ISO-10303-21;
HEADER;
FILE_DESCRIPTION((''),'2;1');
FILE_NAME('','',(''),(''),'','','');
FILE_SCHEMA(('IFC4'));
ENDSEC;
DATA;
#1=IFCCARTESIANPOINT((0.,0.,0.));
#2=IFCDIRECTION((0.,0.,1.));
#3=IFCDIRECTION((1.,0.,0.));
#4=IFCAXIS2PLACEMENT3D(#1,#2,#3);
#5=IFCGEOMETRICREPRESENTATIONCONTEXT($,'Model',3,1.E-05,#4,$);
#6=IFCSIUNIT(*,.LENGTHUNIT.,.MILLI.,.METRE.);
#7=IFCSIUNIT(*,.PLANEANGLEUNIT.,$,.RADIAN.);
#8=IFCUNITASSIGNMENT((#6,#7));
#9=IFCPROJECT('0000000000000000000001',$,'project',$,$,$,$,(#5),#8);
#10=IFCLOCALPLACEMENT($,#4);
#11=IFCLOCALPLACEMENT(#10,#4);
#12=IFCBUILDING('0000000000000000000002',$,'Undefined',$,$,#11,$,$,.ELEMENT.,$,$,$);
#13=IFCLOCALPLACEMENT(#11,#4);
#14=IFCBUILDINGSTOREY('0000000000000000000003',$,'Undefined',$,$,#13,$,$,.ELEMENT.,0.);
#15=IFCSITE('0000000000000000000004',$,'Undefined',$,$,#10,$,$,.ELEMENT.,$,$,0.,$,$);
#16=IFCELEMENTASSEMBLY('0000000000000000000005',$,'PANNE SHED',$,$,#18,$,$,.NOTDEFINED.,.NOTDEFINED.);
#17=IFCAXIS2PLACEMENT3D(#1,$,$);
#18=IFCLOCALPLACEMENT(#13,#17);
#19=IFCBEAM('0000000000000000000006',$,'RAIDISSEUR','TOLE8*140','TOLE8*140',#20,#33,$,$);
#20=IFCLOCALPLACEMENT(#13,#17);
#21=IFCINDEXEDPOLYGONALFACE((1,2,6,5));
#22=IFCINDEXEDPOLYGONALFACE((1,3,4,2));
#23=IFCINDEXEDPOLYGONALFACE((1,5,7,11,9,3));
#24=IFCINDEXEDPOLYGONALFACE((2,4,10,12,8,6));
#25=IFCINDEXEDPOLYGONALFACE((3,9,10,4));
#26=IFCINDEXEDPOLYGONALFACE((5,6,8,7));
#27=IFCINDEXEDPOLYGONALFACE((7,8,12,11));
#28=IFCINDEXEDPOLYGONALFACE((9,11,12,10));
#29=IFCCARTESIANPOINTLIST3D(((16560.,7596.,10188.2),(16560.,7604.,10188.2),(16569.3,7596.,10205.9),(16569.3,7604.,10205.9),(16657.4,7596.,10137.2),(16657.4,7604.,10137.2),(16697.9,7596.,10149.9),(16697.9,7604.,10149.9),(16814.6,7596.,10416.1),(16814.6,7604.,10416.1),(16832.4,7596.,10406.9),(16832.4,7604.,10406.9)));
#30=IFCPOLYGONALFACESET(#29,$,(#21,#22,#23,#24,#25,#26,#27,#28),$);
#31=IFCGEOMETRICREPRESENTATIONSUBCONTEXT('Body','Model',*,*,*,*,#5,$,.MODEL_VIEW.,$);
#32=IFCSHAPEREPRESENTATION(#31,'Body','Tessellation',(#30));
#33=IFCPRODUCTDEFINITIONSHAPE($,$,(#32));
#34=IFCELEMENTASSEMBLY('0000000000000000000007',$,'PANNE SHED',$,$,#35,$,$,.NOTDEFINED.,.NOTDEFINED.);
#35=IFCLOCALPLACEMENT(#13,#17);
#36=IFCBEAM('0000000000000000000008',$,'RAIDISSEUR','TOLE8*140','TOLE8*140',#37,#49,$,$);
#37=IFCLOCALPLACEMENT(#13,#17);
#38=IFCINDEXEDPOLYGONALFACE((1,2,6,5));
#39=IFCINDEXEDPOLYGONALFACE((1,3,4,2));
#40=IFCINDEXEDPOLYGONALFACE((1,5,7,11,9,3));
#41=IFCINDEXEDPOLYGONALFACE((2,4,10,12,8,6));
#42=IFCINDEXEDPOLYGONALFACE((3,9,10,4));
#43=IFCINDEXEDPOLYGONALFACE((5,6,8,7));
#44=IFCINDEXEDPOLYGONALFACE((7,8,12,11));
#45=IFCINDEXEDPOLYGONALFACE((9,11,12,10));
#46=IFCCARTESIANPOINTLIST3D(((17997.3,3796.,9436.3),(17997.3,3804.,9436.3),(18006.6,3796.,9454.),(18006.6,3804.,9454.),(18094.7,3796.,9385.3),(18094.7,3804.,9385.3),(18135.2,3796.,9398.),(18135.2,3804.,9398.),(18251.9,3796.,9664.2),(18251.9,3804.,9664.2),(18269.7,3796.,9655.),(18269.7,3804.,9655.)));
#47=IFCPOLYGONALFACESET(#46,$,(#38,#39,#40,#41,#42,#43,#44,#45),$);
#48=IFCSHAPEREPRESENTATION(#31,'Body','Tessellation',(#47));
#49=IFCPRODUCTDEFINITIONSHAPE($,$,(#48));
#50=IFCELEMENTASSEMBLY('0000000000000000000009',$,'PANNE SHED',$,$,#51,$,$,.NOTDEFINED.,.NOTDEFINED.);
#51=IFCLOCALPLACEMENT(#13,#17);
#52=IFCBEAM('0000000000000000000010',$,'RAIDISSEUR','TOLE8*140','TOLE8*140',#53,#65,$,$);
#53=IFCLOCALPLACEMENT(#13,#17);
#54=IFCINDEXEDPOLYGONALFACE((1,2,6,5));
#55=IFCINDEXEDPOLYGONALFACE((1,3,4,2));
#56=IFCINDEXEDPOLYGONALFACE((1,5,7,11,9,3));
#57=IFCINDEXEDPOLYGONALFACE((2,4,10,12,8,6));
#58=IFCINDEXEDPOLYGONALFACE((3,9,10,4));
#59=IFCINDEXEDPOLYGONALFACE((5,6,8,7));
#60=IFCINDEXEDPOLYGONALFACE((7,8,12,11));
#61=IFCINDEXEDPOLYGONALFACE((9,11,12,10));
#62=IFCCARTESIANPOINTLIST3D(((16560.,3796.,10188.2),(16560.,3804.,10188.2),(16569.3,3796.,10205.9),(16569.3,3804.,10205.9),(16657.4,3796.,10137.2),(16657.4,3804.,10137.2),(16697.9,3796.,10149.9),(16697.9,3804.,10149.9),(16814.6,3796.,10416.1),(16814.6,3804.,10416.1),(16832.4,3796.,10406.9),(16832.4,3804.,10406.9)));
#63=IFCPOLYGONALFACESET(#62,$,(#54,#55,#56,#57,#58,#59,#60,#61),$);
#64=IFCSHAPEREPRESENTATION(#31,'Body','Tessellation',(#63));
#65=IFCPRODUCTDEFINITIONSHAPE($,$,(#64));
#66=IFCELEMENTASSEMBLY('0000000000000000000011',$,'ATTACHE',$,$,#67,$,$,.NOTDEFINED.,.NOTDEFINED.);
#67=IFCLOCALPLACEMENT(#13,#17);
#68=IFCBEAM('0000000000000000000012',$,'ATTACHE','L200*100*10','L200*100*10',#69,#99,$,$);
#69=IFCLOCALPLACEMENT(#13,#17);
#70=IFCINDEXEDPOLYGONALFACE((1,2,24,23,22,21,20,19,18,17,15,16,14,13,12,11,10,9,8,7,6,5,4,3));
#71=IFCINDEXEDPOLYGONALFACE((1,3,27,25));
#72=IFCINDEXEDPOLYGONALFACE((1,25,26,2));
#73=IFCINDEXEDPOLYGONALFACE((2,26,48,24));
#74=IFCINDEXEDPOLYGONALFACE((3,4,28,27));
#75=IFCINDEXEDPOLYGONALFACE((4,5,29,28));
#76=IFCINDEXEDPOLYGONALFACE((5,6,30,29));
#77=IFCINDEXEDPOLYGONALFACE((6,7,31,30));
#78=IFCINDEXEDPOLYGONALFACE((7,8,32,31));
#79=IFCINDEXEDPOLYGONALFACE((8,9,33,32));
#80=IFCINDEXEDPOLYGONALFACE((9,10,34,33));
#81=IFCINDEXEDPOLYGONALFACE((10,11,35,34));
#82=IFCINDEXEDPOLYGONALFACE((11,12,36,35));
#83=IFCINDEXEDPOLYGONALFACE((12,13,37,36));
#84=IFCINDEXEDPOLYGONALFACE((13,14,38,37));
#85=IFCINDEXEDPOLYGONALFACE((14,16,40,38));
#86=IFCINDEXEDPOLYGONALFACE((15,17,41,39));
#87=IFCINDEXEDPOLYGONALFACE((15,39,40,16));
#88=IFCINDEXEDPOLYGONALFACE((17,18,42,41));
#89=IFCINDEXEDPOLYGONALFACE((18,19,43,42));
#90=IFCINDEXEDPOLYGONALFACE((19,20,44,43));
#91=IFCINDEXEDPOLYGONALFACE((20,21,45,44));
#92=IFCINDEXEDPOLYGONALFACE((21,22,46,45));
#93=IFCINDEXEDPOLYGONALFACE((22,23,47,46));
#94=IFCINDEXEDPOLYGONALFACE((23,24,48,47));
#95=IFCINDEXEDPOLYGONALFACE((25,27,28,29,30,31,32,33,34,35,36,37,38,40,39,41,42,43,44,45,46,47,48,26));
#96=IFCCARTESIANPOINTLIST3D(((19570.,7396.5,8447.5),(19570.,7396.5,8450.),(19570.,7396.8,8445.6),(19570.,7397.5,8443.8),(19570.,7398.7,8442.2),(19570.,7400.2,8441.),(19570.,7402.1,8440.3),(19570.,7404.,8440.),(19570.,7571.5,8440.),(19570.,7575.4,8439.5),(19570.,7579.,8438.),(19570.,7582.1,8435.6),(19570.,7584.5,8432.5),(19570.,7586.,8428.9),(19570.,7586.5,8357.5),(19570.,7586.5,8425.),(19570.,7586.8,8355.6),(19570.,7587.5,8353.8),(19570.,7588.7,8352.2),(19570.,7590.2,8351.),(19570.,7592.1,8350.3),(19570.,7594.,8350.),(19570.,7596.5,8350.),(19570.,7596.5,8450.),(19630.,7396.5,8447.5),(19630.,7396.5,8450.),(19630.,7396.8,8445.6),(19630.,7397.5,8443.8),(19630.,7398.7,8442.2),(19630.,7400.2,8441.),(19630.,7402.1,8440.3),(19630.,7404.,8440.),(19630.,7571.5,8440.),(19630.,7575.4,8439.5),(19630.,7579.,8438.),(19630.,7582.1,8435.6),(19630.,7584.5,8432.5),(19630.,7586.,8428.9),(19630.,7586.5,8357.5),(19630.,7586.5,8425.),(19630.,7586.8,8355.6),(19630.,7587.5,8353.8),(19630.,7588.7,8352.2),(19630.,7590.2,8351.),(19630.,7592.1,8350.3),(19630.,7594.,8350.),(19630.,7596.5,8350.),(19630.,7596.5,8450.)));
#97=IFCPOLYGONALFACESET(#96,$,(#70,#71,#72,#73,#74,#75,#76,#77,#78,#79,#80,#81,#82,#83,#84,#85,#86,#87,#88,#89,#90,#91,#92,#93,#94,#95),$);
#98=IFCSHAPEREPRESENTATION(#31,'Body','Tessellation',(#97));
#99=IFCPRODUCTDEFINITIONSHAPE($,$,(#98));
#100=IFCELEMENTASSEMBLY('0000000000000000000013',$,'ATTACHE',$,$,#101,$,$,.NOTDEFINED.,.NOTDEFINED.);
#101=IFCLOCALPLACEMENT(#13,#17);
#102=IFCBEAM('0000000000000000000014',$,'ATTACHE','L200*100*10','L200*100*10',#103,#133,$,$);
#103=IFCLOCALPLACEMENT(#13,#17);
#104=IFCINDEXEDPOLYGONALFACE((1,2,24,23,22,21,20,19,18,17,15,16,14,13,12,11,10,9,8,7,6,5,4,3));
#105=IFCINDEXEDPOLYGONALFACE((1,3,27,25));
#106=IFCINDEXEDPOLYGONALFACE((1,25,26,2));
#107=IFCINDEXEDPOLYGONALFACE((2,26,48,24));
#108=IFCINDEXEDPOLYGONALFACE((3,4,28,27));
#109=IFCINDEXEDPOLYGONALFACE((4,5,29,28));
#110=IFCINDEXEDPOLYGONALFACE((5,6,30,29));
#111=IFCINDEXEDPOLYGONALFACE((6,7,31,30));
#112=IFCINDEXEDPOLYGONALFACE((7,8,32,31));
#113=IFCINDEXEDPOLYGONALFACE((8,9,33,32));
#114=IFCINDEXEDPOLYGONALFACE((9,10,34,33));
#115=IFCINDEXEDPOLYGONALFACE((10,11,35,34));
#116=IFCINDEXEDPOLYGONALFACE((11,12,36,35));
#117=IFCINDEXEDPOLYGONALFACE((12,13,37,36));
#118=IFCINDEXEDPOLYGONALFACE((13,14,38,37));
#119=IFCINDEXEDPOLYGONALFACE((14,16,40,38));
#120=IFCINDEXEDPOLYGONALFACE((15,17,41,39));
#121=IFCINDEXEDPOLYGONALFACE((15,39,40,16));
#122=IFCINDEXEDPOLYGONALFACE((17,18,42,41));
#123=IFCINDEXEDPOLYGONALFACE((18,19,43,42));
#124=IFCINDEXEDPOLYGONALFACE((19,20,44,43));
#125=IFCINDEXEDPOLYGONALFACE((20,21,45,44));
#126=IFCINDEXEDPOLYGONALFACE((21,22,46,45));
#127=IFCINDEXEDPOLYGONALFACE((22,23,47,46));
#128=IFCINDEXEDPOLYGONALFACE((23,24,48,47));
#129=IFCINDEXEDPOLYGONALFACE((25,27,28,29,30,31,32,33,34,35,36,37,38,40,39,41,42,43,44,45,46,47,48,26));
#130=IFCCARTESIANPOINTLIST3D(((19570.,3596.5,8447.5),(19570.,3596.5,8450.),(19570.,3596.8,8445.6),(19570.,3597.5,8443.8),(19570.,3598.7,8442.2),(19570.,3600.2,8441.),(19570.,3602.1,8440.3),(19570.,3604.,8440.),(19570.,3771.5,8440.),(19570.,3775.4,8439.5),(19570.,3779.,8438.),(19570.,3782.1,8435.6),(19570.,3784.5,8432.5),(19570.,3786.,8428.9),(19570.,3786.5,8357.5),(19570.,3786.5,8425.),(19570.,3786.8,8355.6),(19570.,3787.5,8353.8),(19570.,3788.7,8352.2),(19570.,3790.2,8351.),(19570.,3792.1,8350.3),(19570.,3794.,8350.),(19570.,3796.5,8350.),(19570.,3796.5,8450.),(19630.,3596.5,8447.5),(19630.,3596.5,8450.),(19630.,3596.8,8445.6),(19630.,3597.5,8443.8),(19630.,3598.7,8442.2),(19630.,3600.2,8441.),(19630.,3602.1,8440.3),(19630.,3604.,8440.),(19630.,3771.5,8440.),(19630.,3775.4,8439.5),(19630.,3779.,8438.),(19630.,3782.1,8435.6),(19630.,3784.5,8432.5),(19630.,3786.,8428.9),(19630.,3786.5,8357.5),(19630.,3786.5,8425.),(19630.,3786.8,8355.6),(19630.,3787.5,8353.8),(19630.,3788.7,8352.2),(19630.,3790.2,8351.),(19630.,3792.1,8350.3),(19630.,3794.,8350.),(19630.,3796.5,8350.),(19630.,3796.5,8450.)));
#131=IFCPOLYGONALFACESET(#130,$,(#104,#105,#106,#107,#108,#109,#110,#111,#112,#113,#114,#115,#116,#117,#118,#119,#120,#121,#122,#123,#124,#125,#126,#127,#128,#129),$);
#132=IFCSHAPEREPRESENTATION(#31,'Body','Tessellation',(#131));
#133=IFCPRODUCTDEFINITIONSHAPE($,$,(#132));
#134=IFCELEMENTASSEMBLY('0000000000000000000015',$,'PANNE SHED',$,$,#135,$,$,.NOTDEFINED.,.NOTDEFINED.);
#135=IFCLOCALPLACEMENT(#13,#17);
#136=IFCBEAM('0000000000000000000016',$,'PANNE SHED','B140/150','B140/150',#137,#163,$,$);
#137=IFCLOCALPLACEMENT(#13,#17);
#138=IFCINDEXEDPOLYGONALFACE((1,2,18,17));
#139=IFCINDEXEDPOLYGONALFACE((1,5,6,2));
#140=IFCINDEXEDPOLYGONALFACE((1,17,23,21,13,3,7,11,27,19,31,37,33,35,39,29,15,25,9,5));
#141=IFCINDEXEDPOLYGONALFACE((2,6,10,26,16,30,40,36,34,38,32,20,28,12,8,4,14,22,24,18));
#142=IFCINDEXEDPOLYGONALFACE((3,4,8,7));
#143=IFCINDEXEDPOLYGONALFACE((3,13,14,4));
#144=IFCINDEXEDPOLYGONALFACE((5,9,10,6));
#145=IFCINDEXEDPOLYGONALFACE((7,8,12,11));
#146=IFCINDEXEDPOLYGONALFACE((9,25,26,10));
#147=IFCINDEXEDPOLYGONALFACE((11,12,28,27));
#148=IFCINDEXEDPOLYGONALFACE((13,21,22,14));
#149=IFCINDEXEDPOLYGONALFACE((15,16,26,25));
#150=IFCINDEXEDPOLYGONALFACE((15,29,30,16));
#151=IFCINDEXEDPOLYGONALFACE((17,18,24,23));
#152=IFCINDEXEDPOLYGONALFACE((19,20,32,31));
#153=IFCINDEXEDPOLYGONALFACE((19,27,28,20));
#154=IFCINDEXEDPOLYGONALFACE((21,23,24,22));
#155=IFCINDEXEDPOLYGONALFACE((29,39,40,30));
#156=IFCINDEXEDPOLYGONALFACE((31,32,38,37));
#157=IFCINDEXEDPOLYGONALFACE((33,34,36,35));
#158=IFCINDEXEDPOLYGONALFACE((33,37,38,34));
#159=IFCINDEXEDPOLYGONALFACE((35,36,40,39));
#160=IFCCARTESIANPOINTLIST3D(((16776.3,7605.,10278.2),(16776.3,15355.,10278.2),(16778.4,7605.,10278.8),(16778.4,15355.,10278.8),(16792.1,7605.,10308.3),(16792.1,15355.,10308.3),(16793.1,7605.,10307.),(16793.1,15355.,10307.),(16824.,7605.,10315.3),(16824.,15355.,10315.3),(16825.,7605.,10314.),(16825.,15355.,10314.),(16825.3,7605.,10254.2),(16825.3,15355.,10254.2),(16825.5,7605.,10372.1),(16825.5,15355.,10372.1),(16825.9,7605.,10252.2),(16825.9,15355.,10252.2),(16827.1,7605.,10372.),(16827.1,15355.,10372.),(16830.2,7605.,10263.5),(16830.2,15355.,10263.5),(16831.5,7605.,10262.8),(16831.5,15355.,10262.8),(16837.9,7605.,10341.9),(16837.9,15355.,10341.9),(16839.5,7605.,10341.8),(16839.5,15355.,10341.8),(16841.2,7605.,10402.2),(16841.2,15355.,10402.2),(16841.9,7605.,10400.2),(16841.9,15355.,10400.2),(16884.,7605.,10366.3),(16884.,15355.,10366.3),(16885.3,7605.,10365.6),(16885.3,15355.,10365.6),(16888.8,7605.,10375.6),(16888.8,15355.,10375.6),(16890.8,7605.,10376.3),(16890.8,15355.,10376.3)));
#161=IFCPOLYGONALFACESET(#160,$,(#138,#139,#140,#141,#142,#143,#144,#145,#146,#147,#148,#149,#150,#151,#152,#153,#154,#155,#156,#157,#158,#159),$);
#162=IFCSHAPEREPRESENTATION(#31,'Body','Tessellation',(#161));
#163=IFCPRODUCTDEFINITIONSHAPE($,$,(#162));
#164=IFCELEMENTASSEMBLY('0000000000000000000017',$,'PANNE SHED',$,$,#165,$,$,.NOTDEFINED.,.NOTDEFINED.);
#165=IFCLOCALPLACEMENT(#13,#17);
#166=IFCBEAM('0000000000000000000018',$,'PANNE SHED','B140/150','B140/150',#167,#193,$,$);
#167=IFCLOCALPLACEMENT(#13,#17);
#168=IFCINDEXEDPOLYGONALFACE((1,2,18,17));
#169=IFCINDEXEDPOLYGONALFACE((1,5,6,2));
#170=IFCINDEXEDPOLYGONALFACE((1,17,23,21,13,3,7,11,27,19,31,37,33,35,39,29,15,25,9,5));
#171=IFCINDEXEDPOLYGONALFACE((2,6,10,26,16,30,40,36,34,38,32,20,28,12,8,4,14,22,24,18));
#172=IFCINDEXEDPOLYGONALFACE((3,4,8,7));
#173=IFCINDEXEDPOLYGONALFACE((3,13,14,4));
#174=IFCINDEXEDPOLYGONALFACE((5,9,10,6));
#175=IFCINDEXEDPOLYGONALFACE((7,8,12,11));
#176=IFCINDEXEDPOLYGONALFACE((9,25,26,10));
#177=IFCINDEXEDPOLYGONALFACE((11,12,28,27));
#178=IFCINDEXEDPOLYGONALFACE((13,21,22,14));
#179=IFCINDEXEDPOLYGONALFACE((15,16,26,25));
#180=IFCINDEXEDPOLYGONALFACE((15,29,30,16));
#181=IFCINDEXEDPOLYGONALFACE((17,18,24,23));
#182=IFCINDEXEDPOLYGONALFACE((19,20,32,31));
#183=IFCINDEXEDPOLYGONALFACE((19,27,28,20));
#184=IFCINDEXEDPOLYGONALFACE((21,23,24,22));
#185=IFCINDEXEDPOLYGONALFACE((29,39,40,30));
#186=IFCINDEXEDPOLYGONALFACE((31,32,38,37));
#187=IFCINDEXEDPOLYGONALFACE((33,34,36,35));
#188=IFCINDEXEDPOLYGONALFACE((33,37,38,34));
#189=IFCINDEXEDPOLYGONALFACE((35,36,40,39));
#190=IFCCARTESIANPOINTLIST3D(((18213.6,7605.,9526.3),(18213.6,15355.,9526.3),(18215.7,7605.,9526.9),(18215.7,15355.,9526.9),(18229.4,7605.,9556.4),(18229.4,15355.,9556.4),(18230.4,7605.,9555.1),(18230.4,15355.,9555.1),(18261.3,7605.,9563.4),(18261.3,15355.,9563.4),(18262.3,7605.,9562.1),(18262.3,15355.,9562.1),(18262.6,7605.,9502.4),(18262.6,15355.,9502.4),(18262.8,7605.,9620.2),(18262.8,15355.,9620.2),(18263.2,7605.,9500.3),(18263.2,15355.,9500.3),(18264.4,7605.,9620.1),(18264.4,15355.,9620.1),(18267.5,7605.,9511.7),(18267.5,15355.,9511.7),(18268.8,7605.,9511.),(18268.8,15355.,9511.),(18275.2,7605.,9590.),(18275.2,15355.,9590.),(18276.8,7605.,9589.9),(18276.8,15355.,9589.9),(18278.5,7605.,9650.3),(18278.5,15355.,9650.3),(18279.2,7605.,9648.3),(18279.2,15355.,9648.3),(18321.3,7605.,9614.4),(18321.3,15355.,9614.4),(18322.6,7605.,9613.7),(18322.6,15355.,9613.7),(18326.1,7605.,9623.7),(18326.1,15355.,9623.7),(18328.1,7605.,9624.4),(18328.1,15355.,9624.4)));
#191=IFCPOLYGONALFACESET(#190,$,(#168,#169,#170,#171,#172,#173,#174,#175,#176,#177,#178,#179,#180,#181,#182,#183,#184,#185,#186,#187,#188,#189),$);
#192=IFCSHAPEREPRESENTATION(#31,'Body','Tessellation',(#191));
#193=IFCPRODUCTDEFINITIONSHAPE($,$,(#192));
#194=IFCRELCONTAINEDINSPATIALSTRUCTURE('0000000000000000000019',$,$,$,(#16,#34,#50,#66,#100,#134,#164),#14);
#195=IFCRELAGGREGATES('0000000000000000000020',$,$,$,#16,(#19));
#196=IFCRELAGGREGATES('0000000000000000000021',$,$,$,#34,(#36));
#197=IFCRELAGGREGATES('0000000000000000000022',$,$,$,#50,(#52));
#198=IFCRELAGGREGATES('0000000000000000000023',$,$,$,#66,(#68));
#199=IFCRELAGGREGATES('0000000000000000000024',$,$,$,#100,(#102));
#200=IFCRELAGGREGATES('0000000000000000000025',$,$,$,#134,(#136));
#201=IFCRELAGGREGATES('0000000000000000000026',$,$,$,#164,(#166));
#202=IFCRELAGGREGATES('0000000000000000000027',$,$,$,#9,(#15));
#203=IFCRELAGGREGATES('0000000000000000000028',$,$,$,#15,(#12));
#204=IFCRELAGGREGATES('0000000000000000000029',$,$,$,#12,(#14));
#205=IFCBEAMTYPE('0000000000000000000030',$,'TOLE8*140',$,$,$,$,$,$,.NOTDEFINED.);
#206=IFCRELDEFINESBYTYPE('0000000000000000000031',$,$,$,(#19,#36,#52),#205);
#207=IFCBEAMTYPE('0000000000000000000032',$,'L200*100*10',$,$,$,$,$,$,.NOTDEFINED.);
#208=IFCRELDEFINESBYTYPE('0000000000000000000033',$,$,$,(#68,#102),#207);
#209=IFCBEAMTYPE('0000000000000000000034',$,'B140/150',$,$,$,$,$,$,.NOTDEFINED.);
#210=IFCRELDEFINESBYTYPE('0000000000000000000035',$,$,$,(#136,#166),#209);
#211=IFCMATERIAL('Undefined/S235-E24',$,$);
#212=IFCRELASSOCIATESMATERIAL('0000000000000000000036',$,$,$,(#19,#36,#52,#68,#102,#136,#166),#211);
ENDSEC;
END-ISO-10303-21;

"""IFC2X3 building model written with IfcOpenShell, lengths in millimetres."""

from ifc_helpers import new_model, si_unit, frame, origin_with_axes, origin_2d_with_axis, place, context, subcontext, project, spatial, polyline, l_section, outline, extrude, material, type_object, element, aggregate, save


model = new_model("IFC2X3")

# Units and contexts
model_context = context("Model", 3, precision=1e-05, world=origin_with_axes())
body_context = subcontext(model_context, "Body", "Model", "MODEL_VIEW")
ifc_project = project(units=[si_unit("LENGTHUNIT", "METRE", prefix="MILLI"), si_unit("PLANEANGLEUNIT", "RADIAN")], contexts=[model_context])

# Site, building, storey
site_placement = place(None, origin_with_axes())
site = spatial("IfcSite", under=ifc_project, at=site_placement, Name="Undefined", CompositionType="ELEMENT", RefElevation=0.0)
building_placement = place(site_placement, origin_with_axes())
building = spatial("IfcBuilding", under=site, at=building_placement, Name="Undefined", CompositionType="ELEMENT")
storey_placement = place(building_placement, origin_with_axes())
storey = spatial("IfcBuildingStorey", under=building, at=storey_placement, Name="Undefined", CompositionType="ELEMENT", Elevation=0.0)

# Shared definitions
ifc_material_1 = material(Name="Undefined/S235-E24")

# Element assemblies, beams
beam_type_1 = type_object("IfcBeamType", Name="TOLE8*140", PredefinedType="NOTDEFINED")
assembly_1_placement = place(storey_placement, origin_with_axes())
assembly_1 = element("IfcElementAssembly", 1, at=assembly_1_placement, inside=storey, Name="PANNE SHED", AssemblyPlace="NOTDEFINED", PredefinedType="NOTDEFINED")
beam_1_placement = place(assembly_1_placement, frame((16832.4, 7600.0, 10406.9), z_axis=(0.0, -1.0, 0.0), x_axis=(-0.886082, 0.0, 0.463529)))
beam_1 = element("IfcBeam", 2, at=beam_1_placement, type_object=beam_type_1, material=ifc_material_1, Name="RAIDISSEUR", Description="TOLE8*140", ObjectType="TOLE8*140", context=body_context, shape_type="SweptSolid", body=[
    extrude(outline(polyline([(0.0, 0.0), (20.0, 0.0), (140.0, 300.0), (140.0, 320.0), (30.0, 320.0), (0.0, 290.0), (0.0, 0.0)])), frame((0.0, 0.0, -4.0), z_axis=(0.0, 0.0, 1.0), x_axis=(1.0, 0.0, 0.0)), (0.0, 0.0, 1.0), 8.0),
])
aggregate(assembly_1, [beam_1])
assembly_2_placement = place(storey_placement, origin_with_axes())
assembly_2 = element("IfcElementAssembly", 3, at=assembly_2_placement, inside=storey, Name="PANNE SHED", AssemblyPlace="NOTDEFINED", PredefinedType="NOTDEFINED")
beam_2_placement = place(assembly_2_placement, frame((18269.7, 3800.0, 9655.0), z_axis=(0.0, -1.0, 0.0), x_axis=(-0.886082, 0.0, 0.463529)))
beam_2 = element("IfcBeam", 4, at=beam_2_placement, type_object=beam_type_1, material=ifc_material_1, Name="RAIDISSEUR", Description="TOLE8*140", ObjectType="TOLE8*140", context=body_context, shape_type="SweptSolid", body=[
    extrude(outline(polyline([(0.0, 0.0), (20.0, 0.0), (140.0, 300.0), (140.0, 320.0), (30.0, 320.0), (0.0, 290.0), (0.0, 0.0)])), frame((0.0, 0.0, -4.0), z_axis=(0.0, 0.0, 1.0), x_axis=(1.0, 0.0, 0.0)), (0.0, 0.0, 1.0), 8.0),
])
aggregate(assembly_2, [beam_2])
assembly_3_placement = place(storey_placement, origin_with_axes())
assembly_3 = element("IfcElementAssembly", 5, at=assembly_3_placement, inside=storey, Name="PANNE SHED", AssemblyPlace="NOTDEFINED", PredefinedType="NOTDEFINED")
beam_3_placement = place(assembly_3_placement, frame((16832.4, 3800.0, 10406.9), z_axis=(0.0, -1.0, 0.0), x_axis=(-0.886082, 0.0, 0.463529)))
beam_3 = element("IfcBeam", 6, at=beam_3_placement, type_object=beam_type_1, material=ifc_material_1, Name="RAIDISSEUR", Description="TOLE8*140", ObjectType="TOLE8*140", context=body_context, shape_type="SweptSolid", body=[
    extrude(outline(polyline([(0.0, 0.0), (20.0, 0.0), (140.0, 300.0), (140.0, 320.0), (30.0, 320.0), (0.0, 290.0), (0.0, 0.0)])), frame((0.0, 0.0, -4.0), z_axis=(0.0, 0.0, 1.0), x_axis=(1.0, 0.0, 0.0)), (0.0, 0.0, 1.0), 8.0),
])
aggregate(assembly_3, [beam_3])
assembly_4_placement = place(storey_placement, origin_with_axes())
assembly_4 = element("IfcElementAssembly", 7, at=assembly_4_placement, inside=storey, Name="ATTACHE", AssemblyPlace="NOTDEFINED", PredefinedType="NOTDEFINED")
beam_type_2 = type_object("IfcBeamType", Name="L200*100*10", PredefinedType="NOTDEFINED")
beam_4_placement = place(assembly_4_placement, frame((19570.0, 7496.5, 8400.0), z_axis=(0.0, -1.0, 0.0), x_axis=(1.0, 0.0, 0.0)))
beam_4 = element("IfcBeam", 8, at=beam_4_placement, type_object=beam_type_2, material=ifc_material_1, Name="ATTACHE", Description="L200*100*10", ObjectType="L200*100*10", context=body_context, shape_type="SweptSolid", body=[
    extrude(l_section(Depth=200.0, Width=100.0, Thickness=10.0, FilletRadius=15.0, EdgeRadius=7.5, at=origin_2d_with_axis()), frame((60.0, 0.0, 0.0), z_axis=(-1.0, 0.0, 0.0), x_axis=(0.0, -1.0, 0.0)), (0.0, 0.0, 1.0), 60.0),
])
aggregate(assembly_4, [beam_4])
assembly_5_placement = place(storey_placement, origin_with_axes())
assembly_5 = element("IfcElementAssembly", 9, at=assembly_5_placement, inside=storey, Name="ATTACHE", AssemblyPlace="NOTDEFINED", PredefinedType="NOTDEFINED")
beam_5_placement = place(assembly_5_placement, frame((19570.0, 3696.5, 8400.0), z_axis=(0.0, -1.0, 0.0), x_axis=(1.0, 0.0, 0.0)))
beam_5 = element("IfcBeam", 10, at=beam_5_placement, type_object=beam_type_2, material=ifc_material_1, Name="ATTACHE", Description="L200*100*10", ObjectType="L200*100*10", context=body_context, shape_type="SweptSolid", body=[
    extrude(l_section(Depth=200.0, Width=100.0, Thickness=10.0, FilletRadius=15.0, EdgeRadius=7.5, at=origin_2d_with_axis()), frame((60.0, 0.0, 0.0), z_axis=(-1.0, 0.0, 0.0), x_axis=(0.0, -1.0, 0.0)), (0.0, 0.0, 1.0), 60.0),
])
aggregate(assembly_5, [beam_5])
assembly_6_placement = place(storey_placement, origin_with_axes())
assembly_6 = element("IfcElementAssembly", 11, at=assembly_6_placement, inside=storey, Name="PANNE SHED", AssemblyPlace="NOTDEFINED", PredefinedType="NOTDEFINED")
beam_type_3 = type_object("IfcBeamType", Name="B140/150", PredefinedType="NOTDEFINED")
beam_6_placement = place(assembly_6_placement, frame((16833.6, 7605.0, 10327.2), z_axis=(0.463529, 0.0, 0.886082), x_axis=(0.0, 1.0, 0.0)))
beam_6 = element("IfcBeam", 12, at=beam_6_placement, type_object=beam_type_3, material=ifc_material_1, Name="PANNE SHED", Description="B140/150", ObjectType="B140/150", context=body_context, shape_type="SweptSolid", body=[
    extrude(outline(polyline([(-28.0, 36.0), (-28.0, 70.0), (28.0, 70.0), (28.0, 58.0), (26.5, 58.0), (26.5, 68.5), (-26.5, 68.5), (-26.5, 36.7), (-1.5, 15.7), (-1.5, -15.7), (-26.5, -36.7), (-26.5, -68.5), (26.5, -68.5), (26.5, -58.0), (28.0, -58.0), (28.0, -70.0), (-28.0, -70.0), (-28.0, -36.0), (-3.0, -15.0), (-3.0, 15.0), (-28.0, 36.0)])), frame((7750.0, 0.0, 0.0), z_axis=(-1.0, 0.0, 0.0), x_axis=(0.0, -1.0, 0.0)), (0.0, 0.0, 1.0), 7750.0),
])
aggregate(assembly_6, [beam_6])
assembly_7_placement = place(storey_placement, origin_with_axes())
assembly_7 = element("IfcElementAssembly", 13, at=assembly_7_placement, inside=storey, Name="PANNE SHED", AssemblyPlace="NOTDEFINED", PredefinedType="NOTDEFINED")
beam_7_placement = place(assembly_7_placement, frame((18270.9, 7605.0, 9575.3), z_axis=(0.463529, 0.0, 0.886082), x_axis=(0.0, 1.0, 0.0)))
beam_7 = element("IfcBeam", 14, at=beam_7_placement, type_object=beam_type_3, material=ifc_material_1, Name="PANNE SHED", Description="B140/150", ObjectType="B140/150", context=body_context, shape_type="SweptSolid", body=[
    extrude(outline(polyline([(-28.0, 36.0), (-28.0, 70.0), (28.0, 70.0), (28.0, 58.0), (26.5, 58.0), (26.5, 68.5), (-26.5, 68.5), (-26.5, 36.7), (-1.5, 15.7), (-1.5, -15.7), (-26.5, -36.7), (-26.5, -68.5), (26.5, -68.5), (26.5, -58.0), (28.0, -58.0), (28.0, -70.0), (-28.0, -70.0), (-28.0, -36.0), (-3.0, -15.0), (-3.0, 15.0), (-28.0, 36.0)])), frame((7750.0, 0.0, 0.0), z_axis=(-1.0, 0.0, 0.0), x_axis=(0.0, -1.0, 0.0)), (0.0, 0.0, 1.0), 7750.0),
])
aggregate(assembly_7, [beam_7])

save(model, "model.ifc")
